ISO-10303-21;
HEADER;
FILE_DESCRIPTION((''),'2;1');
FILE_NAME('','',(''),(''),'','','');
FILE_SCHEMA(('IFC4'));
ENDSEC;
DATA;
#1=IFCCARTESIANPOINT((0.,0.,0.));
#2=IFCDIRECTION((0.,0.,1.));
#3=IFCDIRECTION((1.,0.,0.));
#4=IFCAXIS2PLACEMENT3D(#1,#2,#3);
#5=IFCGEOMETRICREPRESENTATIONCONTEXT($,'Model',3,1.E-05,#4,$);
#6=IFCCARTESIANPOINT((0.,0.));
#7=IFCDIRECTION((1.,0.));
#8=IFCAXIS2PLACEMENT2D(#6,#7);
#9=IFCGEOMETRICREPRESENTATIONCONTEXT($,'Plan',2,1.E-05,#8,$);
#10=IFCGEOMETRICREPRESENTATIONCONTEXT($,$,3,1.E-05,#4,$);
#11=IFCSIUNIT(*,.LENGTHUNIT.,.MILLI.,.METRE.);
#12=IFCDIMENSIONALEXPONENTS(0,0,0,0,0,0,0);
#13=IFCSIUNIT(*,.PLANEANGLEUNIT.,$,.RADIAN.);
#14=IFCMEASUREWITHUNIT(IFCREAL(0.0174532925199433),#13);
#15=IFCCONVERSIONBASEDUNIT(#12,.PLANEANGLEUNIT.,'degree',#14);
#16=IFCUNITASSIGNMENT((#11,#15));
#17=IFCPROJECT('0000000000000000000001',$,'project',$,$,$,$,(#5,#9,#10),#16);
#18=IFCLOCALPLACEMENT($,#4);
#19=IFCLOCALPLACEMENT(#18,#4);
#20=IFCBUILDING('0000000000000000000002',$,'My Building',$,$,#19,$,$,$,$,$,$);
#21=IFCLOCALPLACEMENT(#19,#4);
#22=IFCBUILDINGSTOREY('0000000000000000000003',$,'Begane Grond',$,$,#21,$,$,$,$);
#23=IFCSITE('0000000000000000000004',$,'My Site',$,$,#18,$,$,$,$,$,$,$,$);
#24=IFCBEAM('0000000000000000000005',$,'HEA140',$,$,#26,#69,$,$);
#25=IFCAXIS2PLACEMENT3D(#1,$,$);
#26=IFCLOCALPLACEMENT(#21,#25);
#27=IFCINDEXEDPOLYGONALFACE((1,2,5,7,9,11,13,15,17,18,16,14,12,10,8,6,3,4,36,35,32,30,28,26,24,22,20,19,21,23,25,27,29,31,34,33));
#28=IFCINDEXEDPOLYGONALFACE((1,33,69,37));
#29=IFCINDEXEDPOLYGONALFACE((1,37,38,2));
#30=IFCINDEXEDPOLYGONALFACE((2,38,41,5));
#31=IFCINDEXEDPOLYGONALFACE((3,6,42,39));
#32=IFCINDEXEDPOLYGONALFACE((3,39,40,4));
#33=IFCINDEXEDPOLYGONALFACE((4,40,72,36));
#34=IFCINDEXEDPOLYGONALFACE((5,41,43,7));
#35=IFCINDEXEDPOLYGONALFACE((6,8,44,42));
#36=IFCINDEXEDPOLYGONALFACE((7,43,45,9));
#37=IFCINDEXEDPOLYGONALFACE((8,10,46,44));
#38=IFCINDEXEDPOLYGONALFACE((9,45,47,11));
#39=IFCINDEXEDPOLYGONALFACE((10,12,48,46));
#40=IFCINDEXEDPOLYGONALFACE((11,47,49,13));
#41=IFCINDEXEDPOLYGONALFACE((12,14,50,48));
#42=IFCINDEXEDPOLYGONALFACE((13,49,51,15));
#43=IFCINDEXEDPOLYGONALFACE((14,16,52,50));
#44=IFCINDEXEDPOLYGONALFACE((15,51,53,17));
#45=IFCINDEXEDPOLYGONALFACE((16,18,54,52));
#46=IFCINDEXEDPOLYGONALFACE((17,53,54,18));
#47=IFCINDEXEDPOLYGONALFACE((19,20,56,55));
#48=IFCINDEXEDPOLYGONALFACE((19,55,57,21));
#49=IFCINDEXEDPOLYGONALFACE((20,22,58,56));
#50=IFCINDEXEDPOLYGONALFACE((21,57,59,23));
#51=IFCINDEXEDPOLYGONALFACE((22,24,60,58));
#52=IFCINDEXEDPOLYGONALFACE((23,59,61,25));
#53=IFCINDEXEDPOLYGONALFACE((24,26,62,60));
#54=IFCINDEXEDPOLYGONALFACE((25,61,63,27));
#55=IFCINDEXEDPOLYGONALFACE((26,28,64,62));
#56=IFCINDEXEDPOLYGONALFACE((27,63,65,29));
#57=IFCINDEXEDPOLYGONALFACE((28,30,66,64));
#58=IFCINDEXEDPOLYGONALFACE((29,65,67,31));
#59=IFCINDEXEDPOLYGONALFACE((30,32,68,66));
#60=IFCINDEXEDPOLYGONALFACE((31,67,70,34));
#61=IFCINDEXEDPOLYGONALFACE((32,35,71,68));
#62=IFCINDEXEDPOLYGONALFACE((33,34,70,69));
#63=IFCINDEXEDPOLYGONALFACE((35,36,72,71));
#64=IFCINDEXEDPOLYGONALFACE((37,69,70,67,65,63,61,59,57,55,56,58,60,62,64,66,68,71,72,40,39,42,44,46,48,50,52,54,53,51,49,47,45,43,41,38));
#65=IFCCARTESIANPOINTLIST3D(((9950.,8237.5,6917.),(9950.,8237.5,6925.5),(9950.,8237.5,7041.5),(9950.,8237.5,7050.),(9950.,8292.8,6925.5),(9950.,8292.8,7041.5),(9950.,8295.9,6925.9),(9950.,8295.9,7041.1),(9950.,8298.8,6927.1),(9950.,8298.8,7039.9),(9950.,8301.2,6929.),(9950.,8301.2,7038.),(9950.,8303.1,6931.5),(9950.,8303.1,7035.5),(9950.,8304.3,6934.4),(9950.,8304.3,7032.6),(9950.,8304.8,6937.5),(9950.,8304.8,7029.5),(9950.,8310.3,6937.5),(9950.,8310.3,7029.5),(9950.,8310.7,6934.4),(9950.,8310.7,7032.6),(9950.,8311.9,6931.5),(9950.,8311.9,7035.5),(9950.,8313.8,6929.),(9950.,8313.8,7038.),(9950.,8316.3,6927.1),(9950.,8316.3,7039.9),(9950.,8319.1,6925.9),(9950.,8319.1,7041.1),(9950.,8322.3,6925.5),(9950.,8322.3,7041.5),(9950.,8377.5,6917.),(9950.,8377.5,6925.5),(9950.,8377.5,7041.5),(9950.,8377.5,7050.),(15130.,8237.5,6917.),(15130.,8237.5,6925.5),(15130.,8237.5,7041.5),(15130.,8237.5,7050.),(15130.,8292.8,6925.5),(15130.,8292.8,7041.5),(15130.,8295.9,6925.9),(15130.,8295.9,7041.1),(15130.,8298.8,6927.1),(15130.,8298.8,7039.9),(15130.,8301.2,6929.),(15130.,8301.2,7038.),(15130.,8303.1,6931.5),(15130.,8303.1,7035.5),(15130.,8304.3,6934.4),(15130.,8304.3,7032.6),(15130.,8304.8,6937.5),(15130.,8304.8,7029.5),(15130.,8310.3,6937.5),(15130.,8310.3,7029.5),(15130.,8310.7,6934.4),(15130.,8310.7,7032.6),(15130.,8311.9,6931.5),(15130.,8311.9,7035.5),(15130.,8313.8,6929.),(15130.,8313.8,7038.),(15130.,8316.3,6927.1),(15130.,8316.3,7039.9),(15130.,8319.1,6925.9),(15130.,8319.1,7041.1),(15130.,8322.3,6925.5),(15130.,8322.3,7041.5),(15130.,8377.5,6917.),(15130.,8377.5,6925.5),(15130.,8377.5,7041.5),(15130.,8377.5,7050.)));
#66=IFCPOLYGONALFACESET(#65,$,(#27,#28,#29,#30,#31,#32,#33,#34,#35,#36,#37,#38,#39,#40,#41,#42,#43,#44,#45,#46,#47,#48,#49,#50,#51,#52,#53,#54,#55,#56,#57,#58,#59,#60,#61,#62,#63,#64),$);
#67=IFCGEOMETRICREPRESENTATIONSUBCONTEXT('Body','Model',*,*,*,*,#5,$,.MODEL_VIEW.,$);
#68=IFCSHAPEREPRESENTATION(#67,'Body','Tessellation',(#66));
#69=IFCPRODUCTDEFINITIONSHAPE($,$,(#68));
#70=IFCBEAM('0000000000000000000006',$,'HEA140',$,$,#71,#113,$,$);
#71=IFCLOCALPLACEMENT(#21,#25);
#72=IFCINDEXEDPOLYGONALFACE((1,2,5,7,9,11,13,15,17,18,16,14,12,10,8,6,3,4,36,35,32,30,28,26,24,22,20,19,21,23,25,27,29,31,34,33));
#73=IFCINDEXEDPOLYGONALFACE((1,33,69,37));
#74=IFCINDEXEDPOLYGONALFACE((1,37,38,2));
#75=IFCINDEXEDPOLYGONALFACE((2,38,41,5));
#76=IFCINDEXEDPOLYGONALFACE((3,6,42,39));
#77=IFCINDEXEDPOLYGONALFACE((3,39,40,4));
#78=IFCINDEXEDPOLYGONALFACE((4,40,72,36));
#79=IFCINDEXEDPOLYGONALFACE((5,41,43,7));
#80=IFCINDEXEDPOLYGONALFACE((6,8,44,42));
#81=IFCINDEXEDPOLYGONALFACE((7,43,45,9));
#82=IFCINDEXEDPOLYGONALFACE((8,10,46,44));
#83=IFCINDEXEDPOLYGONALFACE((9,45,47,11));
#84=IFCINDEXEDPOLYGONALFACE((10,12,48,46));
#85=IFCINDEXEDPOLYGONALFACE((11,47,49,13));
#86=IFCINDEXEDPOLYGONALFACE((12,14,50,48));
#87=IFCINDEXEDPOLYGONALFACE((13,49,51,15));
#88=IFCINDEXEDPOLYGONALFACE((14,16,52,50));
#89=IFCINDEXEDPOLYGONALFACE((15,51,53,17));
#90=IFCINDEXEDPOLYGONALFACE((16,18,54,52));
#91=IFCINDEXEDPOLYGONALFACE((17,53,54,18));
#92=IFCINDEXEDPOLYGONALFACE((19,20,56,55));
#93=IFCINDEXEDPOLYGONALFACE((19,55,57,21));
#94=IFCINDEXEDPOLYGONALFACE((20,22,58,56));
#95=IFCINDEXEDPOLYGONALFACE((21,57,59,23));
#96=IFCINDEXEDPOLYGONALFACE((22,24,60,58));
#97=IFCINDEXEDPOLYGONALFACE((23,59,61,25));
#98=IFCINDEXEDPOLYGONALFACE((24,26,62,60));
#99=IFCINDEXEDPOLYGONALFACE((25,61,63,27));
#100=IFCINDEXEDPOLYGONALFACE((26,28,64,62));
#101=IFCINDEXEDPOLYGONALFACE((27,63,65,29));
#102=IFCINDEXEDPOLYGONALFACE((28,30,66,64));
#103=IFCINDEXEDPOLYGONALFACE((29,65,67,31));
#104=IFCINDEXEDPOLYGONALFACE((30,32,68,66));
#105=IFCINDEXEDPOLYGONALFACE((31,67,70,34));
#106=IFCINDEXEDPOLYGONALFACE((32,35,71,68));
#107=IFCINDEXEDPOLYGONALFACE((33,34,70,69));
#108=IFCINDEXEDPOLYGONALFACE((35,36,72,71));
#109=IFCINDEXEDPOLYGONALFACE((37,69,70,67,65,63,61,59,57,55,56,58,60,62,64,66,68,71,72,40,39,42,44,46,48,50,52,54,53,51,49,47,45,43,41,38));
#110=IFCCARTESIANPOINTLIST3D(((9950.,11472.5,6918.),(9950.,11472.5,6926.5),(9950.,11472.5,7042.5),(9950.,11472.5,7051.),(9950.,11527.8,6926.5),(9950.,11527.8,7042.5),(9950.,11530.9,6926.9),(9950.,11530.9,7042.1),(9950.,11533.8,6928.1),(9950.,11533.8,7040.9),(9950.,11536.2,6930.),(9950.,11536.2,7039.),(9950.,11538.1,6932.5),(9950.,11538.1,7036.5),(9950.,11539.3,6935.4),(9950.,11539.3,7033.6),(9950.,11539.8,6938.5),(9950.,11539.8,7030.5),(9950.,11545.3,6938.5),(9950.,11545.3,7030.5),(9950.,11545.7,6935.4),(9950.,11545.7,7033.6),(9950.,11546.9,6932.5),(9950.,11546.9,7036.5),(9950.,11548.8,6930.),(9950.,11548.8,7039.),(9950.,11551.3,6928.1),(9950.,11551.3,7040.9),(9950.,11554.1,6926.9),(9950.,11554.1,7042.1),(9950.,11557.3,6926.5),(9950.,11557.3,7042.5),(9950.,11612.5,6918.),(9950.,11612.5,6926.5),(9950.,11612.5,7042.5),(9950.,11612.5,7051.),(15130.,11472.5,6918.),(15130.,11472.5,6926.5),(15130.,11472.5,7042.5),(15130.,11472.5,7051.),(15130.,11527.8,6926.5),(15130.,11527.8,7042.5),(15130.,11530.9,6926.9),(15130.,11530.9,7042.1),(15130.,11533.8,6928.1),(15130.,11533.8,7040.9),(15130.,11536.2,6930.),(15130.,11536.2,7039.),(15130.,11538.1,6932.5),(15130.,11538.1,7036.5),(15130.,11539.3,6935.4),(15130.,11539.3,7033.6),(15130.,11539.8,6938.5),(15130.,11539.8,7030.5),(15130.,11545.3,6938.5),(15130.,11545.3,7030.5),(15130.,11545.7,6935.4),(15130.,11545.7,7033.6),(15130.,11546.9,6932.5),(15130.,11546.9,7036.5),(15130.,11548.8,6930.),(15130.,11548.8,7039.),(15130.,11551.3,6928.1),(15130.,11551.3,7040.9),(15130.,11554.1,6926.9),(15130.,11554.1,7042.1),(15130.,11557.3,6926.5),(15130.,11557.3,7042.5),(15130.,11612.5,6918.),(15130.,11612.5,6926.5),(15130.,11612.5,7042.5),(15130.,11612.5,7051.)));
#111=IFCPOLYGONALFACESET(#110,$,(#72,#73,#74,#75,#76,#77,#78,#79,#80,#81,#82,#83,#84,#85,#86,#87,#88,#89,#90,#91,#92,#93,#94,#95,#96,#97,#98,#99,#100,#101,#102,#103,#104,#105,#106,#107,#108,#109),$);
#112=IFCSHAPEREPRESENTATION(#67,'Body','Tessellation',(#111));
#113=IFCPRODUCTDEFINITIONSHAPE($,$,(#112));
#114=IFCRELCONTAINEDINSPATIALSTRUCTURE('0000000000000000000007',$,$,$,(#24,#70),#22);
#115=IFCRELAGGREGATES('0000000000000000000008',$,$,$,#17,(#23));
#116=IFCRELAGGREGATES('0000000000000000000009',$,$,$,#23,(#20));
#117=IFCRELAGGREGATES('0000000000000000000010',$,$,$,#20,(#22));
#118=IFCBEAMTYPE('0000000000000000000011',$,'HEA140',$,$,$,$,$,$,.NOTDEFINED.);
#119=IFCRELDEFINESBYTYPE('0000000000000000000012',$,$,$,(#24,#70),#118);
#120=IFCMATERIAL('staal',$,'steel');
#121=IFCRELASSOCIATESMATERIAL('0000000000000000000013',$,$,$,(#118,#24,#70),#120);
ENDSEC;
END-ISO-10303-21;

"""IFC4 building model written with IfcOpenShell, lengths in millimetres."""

from ifc_helpers import new_model, entity, si_unit, converted_unit, frame, origin_with_axes, origin_2d_with_axis, place, context, subcontext, project, spatial, i_section, extrude, material, material_profile, profile_set, profile_usage, type_object, element, save


model = new_model("IFC4")

# Units and contexts
model_context = context("Model", 3, precision=1e-05, world=origin_with_axes())
plan_context = context("Plan", 2, precision=1e-05, world=origin_2d_with_axis())
context_of_model = context(None, 3, precision=1e-05, world=origin_with_axes())
body_context = subcontext(model_context, "Body", "Model", "MODEL_VIEW")
ifc_project = project(units=[si_unit("LENGTHUNIT", "METRE", prefix="MILLI"), converted_unit("PLANEANGLEUNIT", "degree", entity("IfcReal", 0.0174532925199433), si_unit("PLANEANGLEUNIT", "RADIAN"), dimensions=[0, 0, 0, 0, 0, 0, 0])], contexts=[model_context, plan_context, context_of_model])

# Site, building, storey
site_placement = place(None, origin_with_axes())
site = spatial("IfcSite", under=ifc_project, at=site_placement, Name="My Site")
building_placement = place(site_placement, origin_with_axes())
building = spatial("IfcBuilding", under=site, at=building_placement, Name="My Building")
storey_placement = place(building_placement, origin_with_axes())
storey = spatial("IfcBuildingStorey", under=building, at=storey_placement, Name="Begane Grond")

# Shared definitions
ifc_material = material(Name="staal", Category="steel")

# Beams
ifc_material_profile_1 = material_profile(ifc_material, i_section(OverallWidth=140.0, OverallDepth=133.0, WebThickness=5.5, FlangeThickness=8.5, FilletRadius=12.0))
ifc_profile_set_1 = profile_set([ifc_material_profile_1], Name="HEA140")
beam_type_1 = type_object("IfcBeamType", Name="HEA140", PredefinedType="NOTDEFINED", material=ifc_profile_set_1)
ifc_profile_usage_1 = profile_usage(ifc_profile_set_1)
beam_1_placement = place(storey_placement, frame((15130.0, 8307.5, 6983.5), z_axis=(-1.0, 0.0, 0.0), x_axis=(0.0, -1.0, 0.0)))
element("IfcBeam", 1, at=beam_1_placement, inside=storey, type_object=beam_type_1, material=ifc_profile_usage_1, Name="HEA140", context=body_context, shape_type="SweptSolid", body=[
    extrude(i_section(OverallWidth=140.0, OverallDepth=133.0, WebThickness=5.5, FlangeThickness=8.5, FilletRadius=12.0), origin_with_axes(), (0.0, 0.0, 1.0), 5180.0),
])
ifc_profile_usage_2 = profile_usage(ifc_profile_set_1)
beam_2_placement = place(storey_placement, frame((9950.0, 11542.5, 6984.5), z_axis=(1.0, 0.0, 0.0), x_axis=(0.0, 1.0, 0.0)))
element("IfcBeam", 2, at=beam_2_placement, inside=storey, type_object=beam_type_1, material=ifc_profile_usage_2, Name="HEA140", context=body_context, shape_type="SweptSolid", body=[
    extrude(i_section(OverallWidth=140.0, OverallDepth=133.0, WebThickness=5.5, FlangeThickness=8.5, FilletRadius=12.0), origin_with_axes(), (0.0, 0.0, 1.0), 5180.0),
])

save(model, "model.ifc")
